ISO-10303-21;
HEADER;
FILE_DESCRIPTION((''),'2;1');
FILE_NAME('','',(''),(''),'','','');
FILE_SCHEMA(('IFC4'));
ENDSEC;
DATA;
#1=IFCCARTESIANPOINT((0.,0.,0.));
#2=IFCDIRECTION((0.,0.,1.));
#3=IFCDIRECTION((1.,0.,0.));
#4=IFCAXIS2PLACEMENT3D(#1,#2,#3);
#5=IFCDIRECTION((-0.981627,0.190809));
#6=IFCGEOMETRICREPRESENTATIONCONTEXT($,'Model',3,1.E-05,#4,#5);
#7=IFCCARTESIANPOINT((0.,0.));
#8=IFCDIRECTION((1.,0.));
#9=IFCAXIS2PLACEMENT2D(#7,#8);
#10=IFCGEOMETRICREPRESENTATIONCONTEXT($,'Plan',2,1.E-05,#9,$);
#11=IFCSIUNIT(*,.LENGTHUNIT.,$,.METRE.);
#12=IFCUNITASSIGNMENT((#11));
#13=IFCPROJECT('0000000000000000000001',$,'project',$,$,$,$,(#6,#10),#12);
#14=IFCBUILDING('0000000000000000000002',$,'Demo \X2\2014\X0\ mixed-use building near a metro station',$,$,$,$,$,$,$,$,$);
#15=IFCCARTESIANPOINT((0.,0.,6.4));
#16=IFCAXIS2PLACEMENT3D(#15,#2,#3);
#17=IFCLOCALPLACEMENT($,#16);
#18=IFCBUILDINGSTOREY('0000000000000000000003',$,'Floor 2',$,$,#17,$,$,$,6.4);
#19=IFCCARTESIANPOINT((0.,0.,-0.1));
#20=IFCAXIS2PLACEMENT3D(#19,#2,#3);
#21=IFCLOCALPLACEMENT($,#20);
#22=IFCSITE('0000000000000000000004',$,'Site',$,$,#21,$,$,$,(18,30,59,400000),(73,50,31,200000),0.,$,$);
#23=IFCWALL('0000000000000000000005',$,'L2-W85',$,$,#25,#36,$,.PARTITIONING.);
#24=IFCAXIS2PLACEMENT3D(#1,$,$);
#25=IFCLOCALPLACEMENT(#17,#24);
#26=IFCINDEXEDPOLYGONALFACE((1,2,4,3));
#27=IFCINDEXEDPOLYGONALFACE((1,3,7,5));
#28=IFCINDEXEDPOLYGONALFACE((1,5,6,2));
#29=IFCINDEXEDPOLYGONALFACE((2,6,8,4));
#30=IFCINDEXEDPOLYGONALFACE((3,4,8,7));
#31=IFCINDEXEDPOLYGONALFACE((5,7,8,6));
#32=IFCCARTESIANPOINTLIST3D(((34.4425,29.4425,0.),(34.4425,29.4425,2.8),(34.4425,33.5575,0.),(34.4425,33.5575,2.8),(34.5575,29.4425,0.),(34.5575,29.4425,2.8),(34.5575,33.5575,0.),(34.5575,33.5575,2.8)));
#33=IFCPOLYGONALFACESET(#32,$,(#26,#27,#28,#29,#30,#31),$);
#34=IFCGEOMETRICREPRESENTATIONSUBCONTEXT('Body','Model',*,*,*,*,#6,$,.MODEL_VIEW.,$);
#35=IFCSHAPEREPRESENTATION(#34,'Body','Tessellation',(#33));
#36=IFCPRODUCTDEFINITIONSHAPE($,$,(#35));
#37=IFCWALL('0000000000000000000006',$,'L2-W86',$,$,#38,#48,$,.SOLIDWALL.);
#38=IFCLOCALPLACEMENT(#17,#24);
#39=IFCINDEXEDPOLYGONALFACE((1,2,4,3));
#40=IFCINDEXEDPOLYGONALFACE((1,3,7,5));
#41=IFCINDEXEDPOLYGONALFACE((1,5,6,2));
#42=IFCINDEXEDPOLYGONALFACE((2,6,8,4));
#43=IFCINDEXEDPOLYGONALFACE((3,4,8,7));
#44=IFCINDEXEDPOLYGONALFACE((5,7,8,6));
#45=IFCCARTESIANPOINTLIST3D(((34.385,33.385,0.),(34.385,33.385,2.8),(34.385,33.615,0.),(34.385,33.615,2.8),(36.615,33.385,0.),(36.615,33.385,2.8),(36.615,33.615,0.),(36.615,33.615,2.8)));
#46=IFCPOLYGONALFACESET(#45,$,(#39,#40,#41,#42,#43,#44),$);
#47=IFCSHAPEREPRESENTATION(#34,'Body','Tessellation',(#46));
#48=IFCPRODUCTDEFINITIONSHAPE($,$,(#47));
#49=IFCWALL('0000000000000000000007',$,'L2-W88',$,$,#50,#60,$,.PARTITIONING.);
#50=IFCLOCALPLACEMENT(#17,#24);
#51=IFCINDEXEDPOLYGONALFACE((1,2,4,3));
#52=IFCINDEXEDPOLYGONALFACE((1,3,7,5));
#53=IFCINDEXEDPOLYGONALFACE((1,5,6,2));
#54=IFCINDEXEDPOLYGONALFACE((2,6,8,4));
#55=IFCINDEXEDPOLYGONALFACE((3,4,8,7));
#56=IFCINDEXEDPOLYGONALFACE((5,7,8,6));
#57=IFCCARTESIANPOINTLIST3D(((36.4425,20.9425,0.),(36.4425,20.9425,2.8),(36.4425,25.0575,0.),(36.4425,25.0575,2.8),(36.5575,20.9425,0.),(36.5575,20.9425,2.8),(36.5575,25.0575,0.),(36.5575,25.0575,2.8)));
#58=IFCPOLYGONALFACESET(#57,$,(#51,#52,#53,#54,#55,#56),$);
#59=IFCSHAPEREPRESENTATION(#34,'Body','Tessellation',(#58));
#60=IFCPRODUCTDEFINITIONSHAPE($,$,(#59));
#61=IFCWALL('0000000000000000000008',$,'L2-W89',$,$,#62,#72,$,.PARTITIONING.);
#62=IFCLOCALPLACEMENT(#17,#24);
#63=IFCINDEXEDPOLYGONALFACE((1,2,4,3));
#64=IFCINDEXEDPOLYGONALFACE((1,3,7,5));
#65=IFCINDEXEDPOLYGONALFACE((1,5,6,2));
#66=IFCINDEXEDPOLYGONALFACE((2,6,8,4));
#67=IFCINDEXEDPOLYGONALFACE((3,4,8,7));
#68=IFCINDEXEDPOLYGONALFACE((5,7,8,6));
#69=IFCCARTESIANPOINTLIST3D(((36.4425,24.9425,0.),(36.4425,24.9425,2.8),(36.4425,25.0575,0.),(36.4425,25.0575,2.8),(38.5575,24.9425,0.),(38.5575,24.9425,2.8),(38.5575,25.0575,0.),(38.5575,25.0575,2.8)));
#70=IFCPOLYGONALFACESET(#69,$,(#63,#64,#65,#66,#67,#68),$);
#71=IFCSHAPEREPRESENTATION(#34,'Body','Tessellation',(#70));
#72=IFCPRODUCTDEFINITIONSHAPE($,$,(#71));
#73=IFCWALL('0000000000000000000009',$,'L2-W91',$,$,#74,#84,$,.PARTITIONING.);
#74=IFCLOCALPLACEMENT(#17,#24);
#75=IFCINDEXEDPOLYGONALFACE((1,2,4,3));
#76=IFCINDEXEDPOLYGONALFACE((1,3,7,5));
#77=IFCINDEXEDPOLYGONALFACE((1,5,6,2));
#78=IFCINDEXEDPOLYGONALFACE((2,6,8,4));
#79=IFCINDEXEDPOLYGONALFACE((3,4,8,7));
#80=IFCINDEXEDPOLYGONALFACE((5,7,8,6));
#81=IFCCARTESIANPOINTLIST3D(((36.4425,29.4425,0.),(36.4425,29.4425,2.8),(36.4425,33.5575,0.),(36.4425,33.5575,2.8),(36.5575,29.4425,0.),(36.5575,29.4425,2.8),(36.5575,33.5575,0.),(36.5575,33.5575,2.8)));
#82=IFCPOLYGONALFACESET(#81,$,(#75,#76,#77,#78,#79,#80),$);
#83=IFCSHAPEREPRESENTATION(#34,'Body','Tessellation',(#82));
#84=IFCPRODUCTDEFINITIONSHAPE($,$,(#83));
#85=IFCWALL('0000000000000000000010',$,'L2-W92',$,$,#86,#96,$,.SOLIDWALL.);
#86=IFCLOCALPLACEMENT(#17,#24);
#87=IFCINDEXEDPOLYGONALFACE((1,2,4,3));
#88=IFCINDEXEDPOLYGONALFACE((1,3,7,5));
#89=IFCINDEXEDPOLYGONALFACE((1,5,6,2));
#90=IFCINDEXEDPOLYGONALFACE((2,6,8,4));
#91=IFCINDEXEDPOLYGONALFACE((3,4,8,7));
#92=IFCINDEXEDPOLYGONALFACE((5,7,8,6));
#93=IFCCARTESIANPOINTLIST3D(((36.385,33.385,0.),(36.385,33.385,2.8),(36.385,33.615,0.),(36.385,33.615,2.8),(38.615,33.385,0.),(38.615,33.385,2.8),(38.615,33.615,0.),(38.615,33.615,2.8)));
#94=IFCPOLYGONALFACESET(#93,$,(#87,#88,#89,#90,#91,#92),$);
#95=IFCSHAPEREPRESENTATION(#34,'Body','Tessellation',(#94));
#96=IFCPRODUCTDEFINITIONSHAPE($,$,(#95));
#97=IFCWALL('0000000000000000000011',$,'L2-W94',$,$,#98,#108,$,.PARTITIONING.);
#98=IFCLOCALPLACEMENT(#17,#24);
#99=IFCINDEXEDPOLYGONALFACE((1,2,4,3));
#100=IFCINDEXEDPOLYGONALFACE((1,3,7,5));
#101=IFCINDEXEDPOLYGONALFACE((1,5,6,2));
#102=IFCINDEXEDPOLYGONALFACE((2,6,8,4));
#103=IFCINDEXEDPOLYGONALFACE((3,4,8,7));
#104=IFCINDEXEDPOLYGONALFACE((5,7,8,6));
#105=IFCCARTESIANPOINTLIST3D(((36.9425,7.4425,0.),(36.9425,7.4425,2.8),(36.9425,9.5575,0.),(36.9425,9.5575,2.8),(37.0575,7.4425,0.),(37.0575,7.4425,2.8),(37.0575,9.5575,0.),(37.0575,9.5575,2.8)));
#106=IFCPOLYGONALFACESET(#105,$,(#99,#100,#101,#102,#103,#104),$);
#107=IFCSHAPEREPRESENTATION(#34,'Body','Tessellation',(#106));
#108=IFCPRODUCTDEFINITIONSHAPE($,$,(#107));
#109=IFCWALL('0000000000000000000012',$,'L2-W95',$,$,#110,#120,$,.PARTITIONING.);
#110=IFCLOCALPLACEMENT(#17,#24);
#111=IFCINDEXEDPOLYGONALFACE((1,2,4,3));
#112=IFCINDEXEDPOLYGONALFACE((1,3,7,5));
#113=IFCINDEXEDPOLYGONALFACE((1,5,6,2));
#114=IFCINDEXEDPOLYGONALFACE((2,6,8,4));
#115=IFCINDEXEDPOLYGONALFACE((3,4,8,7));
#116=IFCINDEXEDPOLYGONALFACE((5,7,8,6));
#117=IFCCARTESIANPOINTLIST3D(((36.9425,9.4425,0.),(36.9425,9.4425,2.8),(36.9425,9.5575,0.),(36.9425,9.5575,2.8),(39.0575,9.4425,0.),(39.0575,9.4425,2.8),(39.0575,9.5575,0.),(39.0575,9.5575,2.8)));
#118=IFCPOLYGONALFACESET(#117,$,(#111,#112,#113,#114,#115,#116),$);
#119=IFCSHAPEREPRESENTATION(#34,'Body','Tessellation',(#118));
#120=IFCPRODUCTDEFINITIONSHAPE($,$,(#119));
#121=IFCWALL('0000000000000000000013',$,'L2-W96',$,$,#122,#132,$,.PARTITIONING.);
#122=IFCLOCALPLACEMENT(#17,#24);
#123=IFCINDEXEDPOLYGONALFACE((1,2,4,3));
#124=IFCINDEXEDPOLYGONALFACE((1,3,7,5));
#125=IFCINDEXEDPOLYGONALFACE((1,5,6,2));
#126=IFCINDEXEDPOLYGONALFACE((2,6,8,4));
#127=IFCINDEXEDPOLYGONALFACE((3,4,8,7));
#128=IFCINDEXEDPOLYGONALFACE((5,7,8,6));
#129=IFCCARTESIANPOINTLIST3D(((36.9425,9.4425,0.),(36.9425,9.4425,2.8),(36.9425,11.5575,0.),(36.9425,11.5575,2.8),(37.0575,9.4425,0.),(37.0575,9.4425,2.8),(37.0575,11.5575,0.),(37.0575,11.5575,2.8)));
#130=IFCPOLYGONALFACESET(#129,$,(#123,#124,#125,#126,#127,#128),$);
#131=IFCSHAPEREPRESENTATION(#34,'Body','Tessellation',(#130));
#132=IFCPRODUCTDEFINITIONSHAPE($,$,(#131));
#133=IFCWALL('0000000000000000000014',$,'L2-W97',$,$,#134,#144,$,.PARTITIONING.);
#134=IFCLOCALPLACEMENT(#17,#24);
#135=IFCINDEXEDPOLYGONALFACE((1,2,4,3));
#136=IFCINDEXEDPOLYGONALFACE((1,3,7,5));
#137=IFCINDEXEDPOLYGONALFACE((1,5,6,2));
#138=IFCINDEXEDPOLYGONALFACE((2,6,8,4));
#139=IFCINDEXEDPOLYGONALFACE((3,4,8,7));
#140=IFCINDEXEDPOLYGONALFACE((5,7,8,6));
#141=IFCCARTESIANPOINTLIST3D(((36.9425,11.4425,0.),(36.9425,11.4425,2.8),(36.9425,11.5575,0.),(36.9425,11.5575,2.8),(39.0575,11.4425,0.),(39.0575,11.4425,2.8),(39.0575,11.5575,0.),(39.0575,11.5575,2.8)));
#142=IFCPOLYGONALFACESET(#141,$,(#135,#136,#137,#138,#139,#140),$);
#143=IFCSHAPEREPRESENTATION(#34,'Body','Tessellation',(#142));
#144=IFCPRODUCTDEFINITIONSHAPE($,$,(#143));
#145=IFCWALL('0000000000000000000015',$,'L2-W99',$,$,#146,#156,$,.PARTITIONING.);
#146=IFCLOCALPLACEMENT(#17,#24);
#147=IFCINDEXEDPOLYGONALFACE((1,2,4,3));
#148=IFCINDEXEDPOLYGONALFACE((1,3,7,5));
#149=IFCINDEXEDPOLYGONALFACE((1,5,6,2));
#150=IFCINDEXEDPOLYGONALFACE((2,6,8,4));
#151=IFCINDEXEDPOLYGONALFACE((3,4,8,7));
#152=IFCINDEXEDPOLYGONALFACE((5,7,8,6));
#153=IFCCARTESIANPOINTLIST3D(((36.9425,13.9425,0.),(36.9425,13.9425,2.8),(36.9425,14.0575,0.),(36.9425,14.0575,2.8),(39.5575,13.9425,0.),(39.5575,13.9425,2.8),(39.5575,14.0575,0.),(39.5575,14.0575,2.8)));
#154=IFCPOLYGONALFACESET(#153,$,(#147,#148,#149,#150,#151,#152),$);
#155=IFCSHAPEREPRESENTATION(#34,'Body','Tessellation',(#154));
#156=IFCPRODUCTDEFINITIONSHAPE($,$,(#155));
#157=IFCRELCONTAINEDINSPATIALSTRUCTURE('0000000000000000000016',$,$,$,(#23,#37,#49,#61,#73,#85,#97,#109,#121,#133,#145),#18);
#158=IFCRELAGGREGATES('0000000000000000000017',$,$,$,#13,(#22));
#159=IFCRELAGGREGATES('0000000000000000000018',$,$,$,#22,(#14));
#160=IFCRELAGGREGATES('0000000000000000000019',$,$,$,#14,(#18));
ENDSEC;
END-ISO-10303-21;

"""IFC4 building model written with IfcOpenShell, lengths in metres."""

from ifc_helpers import new_model, si_unit, direction, frame, origin_with_axes, origin_2d_with_axis, place, context, subcontext, project, spatial, line, indexed_curve, outline, extrude, element, save


model = new_model("IFC4")

# Units and contexts
model_context = context("Model", 3, precision=1e-05, world=origin_with_axes(), true_north=direction((-0.981627, 0.190809)))
plan_context = context("Plan", 2, precision=1e-05, world=origin_2d_with_axis())
body_context = subcontext(model_context, "Body", "Model", "MODEL_VIEW")
ifc_project = project(units=[si_unit("LENGTHUNIT", "METRE")], contexts=[model_context, plan_context])

# Site, building, storey
site_placement = place(None, frame((0.0, 0.0, -0.1), z_axis=(0.0, 0.0, 1.0), x_axis=(1.0, 0.0, 0.0)))
site = spatial("IfcSite", under=ifc_project, at=site_placement, Name="Site", RefLatitude=(18, 30, 59, 400000), RefLongitude=(73, 50, 31, 200000), RefElevation=0.0)
building = spatial("IfcBuilding", under=site, Name="Demo — mixed-use building near a metro station")
storey_placement = place(None, frame((0.0, 0.0, 6.4), z_axis=(0.0, 0.0, 1.0), x_axis=(1.0, 0.0, 0.0)))
storey = spatial("IfcBuildingStorey", under=building, at=storey_placement, Name="Floor 2", Elevation=6.4)

# Walls
wall_1_placement = place(storey_placement, frame((0.0, 0.0, -6.4), z_axis=(0.0, 0.0, 1.0), x_axis=(1.0, 0.0, 0.0)))
element("IfcWall", 1, at=wall_1_placement, inside=storey, Name="L2-W85", PredefinedType="PARTITIONING", context=body_context, shape_type="SweptSolid", body=[
    extrude(outline(indexed_curve([(34.4425, 29.4425), (34.4425, 33.5575), (34.5575, 33.5575), (34.5575, 29.4425)], segments=[line(1, 2, 3, 4, 1)])), frame((0.0, 0.0, 6.4), z_axis=(0.0, 0.0, 1.0), x_axis=(1.0, 0.0, 0.0)), (0.0, 0.0, 1.0), 2.8),
])
wall_2_placement = place(storey_placement, frame((0.0, 0.0, -6.4), z_axis=(0.0, 0.0, 1.0), x_axis=(1.0, 0.0, 0.0)))
element("IfcWall", 2, at=wall_2_placement, inside=storey, Name="L2-W86", PredefinedType="SOLIDWALL", context=body_context, shape_type="SweptSolid", body=[
    extrude(outline(indexed_curve([(36.615, 33.385), (34.385, 33.385), (34.385, 33.615), (36.615, 33.615)], segments=[line(1, 2, 3, 4, 1)])), frame((0.0, 0.0, 6.4), z_axis=(0.0, 0.0, 1.0), x_axis=(1.0, 0.0, 0.0)), (0.0, 0.0, 1.0), 2.8),
])

# Walls
wall_3_placement = place(storey_placement, frame((0.0, 0.0, -6.4), z_axis=(0.0, 0.0, 1.0), x_axis=(1.0, 0.0, 0.0)))
element("IfcWall", 3, at=wall_3_placement, inside=storey, Name="L2-W88", PredefinedType="PARTITIONING", context=body_context, shape_type="SweptSolid", body=[
    extrude(outline(indexed_curve([(36.5575, 25.0575), (36.5575, 20.9425), (36.4425, 20.9425), (36.4425, 25.0575)], segments=[line(1, 2, 3, 4, 1)])), frame((0.0, 0.0, 6.4), z_axis=(0.0, 0.0, 1.0), x_axis=(1.0, 0.0, 0.0)), (0.0, 0.0, 1.0), 2.8),
])
wall_4_placement = place(storey_placement, frame((0.0, 0.0, -6.4), z_axis=(0.0, 0.0, 1.0), x_axis=(1.0, 0.0, 0.0)))
element("IfcWall", 4, at=wall_4_placement, inside=storey, Name="L2-W89", PredefinedType="PARTITIONING", context=body_context, shape_type="SweptSolid", body=[
    extrude(outline(indexed_curve([(38.5575, 24.9425), (36.4425, 24.9425), (36.4425, 25.0575), (38.5575, 25.0575)], segments=[line(1, 2, 3, 4, 1)])), frame((0.0, 0.0, 6.4), z_axis=(0.0, 0.0, 1.0), x_axis=(1.0, 0.0, 0.0)), (0.0, 0.0, 1.0), 2.8),
])

# Walls
wall_5_placement = place(storey_placement, frame((0.0, 0.0, -6.4), z_axis=(0.0, 0.0, 1.0), x_axis=(1.0, 0.0, 0.0)))
element("IfcWall", 5, at=wall_5_placement, inside=storey, Name="L2-W91", PredefinedType="PARTITIONING", context=body_context, shape_type="SweptSolid", body=[
    extrude(outline(indexed_curve([(36.5575, 33.5575), (36.5575, 29.4425), (36.4425, 29.4425), (36.4425, 33.5575)], segments=[line(1, 2, 3, 4, 1)])), frame((0.0, 0.0, 6.4), z_axis=(0.0, 0.0, 1.0), x_axis=(1.0, 0.0, 0.0)), (0.0, 0.0, 1.0), 2.8),
])
wall_6_placement = place(storey_placement, frame((0.0, 0.0, -6.4), z_axis=(0.0, 0.0, 1.0), x_axis=(1.0, 0.0, 0.0)))
element("IfcWall", 6, at=wall_6_placement, inside=storey, Name="L2-W92", PredefinedType="SOLIDWALL", context=body_context, shape_type="SweptSolid", body=[
    extrude(outline(indexed_curve([(38.615, 33.385), (36.385, 33.385), (36.385, 33.615), (38.615, 33.615)], segments=[line(1, 2, 3, 4, 1)])), frame((0.0, 0.0, 6.4), z_axis=(0.0, 0.0, 1.0), x_axis=(1.0, 0.0, 0.0)), (0.0, 0.0, 1.0), 2.8),
])

# Walls
wall_7_placement = place(storey_placement, frame((0.0, 0.0, -6.4), z_axis=(0.0, 0.0, 1.0), x_axis=(1.0, 0.0, 0.0)))
element("IfcWall", 7, at=wall_7_placement, inside=storey, Name="L2-W94", PredefinedType="PARTITIONING", context=body_context, shape_type="SweptSolid", body=[
    extrude(outline(indexed_curve([(37.0575, 9.5575), (37.0575, 7.4425), (36.9425, 7.4425), (36.9425, 9.5575)], segments=[line(1, 2, 3, 4, 1)])), frame((0.0, 0.0, 6.4), z_axis=(0.0, 0.0, 1.0), x_axis=(1.0, 0.0, 0.0)), (0.0, 0.0, 1.0), 2.8),
])
wall_8_placement = place(storey_placement, frame((0.0, 0.0, -6.4), z_axis=(0.0, 0.0, 1.0), x_axis=(1.0, 0.0, 0.0)))
element("IfcWall", 8, at=wall_8_placement, inside=storey, Name="L2-W95", PredefinedType="PARTITIONING", context=body_context, shape_type="SweptSolid", body=[
    extrude(outline(indexed_curve([(39.0575, 9.4425), (36.9425, 9.4425), (36.9425, 9.5575), (39.0575, 9.5575)], segments=[line(1, 2, 3, 4, 1)])), frame((0.0, 0.0, 6.4), z_axis=(0.0, 0.0, 1.0), x_axis=(1.0, 0.0, 0.0)), (0.0, 0.0, 1.0), 2.8),
])
wall_9_placement = place(storey_placement, frame((0.0, 0.0, -6.4), z_axis=(0.0, 0.0, 1.0), x_axis=(1.0, 0.0, 0.0)))
element("IfcWall", 9, at=wall_9_placement, inside=storey, Name="L2-W96", PredefinedType="PARTITIONING", context=body_context, shape_type="SweptSolid", body=[
    extrude(outline(indexed_curve([(37.0575, 11.5575), (37.0575, 9.4425), (36.9425, 9.4425), (36.9425, 11.5575)], segments=[line(1, 2, 3, 4, 1)])), frame((0.0, 0.0, 6.4), z_axis=(0.0, 0.0, 1.0), x_axis=(1.0, 0.0, 0.0)), (0.0, 0.0, 1.0), 2.8),
])
wall_10_placement = place(storey_placement, frame((0.0, 0.0, -6.4), z_axis=(0.0, 0.0, 1.0), x_axis=(1.0, 0.0, 0.0)))
element("IfcWall", 10, at=wall_10_placement, inside=storey, Name="L2-W97", PredefinedType="PARTITIONING", context=body_context, shape_type="SweptSolid", body=[
    extrude(outline(indexed_curve([(36.9425, 11.5575), (39.0575, 11.5575), (39.0575, 11.4425), (36.9425, 11.4425)], segments=[line(1, 2, 3, 4, 1)])), frame((0.0, 0.0, 6.4), z_axis=(0.0, 0.0, 1.0), x_axis=(1.0, 0.0, 0.0)), (0.0, 0.0, 1.0), 2.8),
])

# Wall
wall_11_placement = place(storey_placement, frame((0.0, 0.0, -6.4), z_axis=(0.0, 0.0, 1.0), x_axis=(1.0, 0.0, 0.0)))
element("IfcWall", 11, at=wall_11_placement, inside=storey, Name="L2-W99", PredefinedType="PARTITIONING", context=body_context, shape_type="SweptSolid", body=[
    extrude(outline(indexed_curve([(39.5575, 13.9425), (36.9425, 13.9425), (36.9425, 14.0575), (39.5575, 14.0575)], segments=[line(1, 2, 3, 4, 1)])), frame((0.0, 0.0, 6.4), z_axis=(0.0, 0.0, 1.0), x_axis=(1.0, 0.0, 0.0)), (0.0, 0.0, 1.0), 2.8),
])

save(model, "model.ifc")
